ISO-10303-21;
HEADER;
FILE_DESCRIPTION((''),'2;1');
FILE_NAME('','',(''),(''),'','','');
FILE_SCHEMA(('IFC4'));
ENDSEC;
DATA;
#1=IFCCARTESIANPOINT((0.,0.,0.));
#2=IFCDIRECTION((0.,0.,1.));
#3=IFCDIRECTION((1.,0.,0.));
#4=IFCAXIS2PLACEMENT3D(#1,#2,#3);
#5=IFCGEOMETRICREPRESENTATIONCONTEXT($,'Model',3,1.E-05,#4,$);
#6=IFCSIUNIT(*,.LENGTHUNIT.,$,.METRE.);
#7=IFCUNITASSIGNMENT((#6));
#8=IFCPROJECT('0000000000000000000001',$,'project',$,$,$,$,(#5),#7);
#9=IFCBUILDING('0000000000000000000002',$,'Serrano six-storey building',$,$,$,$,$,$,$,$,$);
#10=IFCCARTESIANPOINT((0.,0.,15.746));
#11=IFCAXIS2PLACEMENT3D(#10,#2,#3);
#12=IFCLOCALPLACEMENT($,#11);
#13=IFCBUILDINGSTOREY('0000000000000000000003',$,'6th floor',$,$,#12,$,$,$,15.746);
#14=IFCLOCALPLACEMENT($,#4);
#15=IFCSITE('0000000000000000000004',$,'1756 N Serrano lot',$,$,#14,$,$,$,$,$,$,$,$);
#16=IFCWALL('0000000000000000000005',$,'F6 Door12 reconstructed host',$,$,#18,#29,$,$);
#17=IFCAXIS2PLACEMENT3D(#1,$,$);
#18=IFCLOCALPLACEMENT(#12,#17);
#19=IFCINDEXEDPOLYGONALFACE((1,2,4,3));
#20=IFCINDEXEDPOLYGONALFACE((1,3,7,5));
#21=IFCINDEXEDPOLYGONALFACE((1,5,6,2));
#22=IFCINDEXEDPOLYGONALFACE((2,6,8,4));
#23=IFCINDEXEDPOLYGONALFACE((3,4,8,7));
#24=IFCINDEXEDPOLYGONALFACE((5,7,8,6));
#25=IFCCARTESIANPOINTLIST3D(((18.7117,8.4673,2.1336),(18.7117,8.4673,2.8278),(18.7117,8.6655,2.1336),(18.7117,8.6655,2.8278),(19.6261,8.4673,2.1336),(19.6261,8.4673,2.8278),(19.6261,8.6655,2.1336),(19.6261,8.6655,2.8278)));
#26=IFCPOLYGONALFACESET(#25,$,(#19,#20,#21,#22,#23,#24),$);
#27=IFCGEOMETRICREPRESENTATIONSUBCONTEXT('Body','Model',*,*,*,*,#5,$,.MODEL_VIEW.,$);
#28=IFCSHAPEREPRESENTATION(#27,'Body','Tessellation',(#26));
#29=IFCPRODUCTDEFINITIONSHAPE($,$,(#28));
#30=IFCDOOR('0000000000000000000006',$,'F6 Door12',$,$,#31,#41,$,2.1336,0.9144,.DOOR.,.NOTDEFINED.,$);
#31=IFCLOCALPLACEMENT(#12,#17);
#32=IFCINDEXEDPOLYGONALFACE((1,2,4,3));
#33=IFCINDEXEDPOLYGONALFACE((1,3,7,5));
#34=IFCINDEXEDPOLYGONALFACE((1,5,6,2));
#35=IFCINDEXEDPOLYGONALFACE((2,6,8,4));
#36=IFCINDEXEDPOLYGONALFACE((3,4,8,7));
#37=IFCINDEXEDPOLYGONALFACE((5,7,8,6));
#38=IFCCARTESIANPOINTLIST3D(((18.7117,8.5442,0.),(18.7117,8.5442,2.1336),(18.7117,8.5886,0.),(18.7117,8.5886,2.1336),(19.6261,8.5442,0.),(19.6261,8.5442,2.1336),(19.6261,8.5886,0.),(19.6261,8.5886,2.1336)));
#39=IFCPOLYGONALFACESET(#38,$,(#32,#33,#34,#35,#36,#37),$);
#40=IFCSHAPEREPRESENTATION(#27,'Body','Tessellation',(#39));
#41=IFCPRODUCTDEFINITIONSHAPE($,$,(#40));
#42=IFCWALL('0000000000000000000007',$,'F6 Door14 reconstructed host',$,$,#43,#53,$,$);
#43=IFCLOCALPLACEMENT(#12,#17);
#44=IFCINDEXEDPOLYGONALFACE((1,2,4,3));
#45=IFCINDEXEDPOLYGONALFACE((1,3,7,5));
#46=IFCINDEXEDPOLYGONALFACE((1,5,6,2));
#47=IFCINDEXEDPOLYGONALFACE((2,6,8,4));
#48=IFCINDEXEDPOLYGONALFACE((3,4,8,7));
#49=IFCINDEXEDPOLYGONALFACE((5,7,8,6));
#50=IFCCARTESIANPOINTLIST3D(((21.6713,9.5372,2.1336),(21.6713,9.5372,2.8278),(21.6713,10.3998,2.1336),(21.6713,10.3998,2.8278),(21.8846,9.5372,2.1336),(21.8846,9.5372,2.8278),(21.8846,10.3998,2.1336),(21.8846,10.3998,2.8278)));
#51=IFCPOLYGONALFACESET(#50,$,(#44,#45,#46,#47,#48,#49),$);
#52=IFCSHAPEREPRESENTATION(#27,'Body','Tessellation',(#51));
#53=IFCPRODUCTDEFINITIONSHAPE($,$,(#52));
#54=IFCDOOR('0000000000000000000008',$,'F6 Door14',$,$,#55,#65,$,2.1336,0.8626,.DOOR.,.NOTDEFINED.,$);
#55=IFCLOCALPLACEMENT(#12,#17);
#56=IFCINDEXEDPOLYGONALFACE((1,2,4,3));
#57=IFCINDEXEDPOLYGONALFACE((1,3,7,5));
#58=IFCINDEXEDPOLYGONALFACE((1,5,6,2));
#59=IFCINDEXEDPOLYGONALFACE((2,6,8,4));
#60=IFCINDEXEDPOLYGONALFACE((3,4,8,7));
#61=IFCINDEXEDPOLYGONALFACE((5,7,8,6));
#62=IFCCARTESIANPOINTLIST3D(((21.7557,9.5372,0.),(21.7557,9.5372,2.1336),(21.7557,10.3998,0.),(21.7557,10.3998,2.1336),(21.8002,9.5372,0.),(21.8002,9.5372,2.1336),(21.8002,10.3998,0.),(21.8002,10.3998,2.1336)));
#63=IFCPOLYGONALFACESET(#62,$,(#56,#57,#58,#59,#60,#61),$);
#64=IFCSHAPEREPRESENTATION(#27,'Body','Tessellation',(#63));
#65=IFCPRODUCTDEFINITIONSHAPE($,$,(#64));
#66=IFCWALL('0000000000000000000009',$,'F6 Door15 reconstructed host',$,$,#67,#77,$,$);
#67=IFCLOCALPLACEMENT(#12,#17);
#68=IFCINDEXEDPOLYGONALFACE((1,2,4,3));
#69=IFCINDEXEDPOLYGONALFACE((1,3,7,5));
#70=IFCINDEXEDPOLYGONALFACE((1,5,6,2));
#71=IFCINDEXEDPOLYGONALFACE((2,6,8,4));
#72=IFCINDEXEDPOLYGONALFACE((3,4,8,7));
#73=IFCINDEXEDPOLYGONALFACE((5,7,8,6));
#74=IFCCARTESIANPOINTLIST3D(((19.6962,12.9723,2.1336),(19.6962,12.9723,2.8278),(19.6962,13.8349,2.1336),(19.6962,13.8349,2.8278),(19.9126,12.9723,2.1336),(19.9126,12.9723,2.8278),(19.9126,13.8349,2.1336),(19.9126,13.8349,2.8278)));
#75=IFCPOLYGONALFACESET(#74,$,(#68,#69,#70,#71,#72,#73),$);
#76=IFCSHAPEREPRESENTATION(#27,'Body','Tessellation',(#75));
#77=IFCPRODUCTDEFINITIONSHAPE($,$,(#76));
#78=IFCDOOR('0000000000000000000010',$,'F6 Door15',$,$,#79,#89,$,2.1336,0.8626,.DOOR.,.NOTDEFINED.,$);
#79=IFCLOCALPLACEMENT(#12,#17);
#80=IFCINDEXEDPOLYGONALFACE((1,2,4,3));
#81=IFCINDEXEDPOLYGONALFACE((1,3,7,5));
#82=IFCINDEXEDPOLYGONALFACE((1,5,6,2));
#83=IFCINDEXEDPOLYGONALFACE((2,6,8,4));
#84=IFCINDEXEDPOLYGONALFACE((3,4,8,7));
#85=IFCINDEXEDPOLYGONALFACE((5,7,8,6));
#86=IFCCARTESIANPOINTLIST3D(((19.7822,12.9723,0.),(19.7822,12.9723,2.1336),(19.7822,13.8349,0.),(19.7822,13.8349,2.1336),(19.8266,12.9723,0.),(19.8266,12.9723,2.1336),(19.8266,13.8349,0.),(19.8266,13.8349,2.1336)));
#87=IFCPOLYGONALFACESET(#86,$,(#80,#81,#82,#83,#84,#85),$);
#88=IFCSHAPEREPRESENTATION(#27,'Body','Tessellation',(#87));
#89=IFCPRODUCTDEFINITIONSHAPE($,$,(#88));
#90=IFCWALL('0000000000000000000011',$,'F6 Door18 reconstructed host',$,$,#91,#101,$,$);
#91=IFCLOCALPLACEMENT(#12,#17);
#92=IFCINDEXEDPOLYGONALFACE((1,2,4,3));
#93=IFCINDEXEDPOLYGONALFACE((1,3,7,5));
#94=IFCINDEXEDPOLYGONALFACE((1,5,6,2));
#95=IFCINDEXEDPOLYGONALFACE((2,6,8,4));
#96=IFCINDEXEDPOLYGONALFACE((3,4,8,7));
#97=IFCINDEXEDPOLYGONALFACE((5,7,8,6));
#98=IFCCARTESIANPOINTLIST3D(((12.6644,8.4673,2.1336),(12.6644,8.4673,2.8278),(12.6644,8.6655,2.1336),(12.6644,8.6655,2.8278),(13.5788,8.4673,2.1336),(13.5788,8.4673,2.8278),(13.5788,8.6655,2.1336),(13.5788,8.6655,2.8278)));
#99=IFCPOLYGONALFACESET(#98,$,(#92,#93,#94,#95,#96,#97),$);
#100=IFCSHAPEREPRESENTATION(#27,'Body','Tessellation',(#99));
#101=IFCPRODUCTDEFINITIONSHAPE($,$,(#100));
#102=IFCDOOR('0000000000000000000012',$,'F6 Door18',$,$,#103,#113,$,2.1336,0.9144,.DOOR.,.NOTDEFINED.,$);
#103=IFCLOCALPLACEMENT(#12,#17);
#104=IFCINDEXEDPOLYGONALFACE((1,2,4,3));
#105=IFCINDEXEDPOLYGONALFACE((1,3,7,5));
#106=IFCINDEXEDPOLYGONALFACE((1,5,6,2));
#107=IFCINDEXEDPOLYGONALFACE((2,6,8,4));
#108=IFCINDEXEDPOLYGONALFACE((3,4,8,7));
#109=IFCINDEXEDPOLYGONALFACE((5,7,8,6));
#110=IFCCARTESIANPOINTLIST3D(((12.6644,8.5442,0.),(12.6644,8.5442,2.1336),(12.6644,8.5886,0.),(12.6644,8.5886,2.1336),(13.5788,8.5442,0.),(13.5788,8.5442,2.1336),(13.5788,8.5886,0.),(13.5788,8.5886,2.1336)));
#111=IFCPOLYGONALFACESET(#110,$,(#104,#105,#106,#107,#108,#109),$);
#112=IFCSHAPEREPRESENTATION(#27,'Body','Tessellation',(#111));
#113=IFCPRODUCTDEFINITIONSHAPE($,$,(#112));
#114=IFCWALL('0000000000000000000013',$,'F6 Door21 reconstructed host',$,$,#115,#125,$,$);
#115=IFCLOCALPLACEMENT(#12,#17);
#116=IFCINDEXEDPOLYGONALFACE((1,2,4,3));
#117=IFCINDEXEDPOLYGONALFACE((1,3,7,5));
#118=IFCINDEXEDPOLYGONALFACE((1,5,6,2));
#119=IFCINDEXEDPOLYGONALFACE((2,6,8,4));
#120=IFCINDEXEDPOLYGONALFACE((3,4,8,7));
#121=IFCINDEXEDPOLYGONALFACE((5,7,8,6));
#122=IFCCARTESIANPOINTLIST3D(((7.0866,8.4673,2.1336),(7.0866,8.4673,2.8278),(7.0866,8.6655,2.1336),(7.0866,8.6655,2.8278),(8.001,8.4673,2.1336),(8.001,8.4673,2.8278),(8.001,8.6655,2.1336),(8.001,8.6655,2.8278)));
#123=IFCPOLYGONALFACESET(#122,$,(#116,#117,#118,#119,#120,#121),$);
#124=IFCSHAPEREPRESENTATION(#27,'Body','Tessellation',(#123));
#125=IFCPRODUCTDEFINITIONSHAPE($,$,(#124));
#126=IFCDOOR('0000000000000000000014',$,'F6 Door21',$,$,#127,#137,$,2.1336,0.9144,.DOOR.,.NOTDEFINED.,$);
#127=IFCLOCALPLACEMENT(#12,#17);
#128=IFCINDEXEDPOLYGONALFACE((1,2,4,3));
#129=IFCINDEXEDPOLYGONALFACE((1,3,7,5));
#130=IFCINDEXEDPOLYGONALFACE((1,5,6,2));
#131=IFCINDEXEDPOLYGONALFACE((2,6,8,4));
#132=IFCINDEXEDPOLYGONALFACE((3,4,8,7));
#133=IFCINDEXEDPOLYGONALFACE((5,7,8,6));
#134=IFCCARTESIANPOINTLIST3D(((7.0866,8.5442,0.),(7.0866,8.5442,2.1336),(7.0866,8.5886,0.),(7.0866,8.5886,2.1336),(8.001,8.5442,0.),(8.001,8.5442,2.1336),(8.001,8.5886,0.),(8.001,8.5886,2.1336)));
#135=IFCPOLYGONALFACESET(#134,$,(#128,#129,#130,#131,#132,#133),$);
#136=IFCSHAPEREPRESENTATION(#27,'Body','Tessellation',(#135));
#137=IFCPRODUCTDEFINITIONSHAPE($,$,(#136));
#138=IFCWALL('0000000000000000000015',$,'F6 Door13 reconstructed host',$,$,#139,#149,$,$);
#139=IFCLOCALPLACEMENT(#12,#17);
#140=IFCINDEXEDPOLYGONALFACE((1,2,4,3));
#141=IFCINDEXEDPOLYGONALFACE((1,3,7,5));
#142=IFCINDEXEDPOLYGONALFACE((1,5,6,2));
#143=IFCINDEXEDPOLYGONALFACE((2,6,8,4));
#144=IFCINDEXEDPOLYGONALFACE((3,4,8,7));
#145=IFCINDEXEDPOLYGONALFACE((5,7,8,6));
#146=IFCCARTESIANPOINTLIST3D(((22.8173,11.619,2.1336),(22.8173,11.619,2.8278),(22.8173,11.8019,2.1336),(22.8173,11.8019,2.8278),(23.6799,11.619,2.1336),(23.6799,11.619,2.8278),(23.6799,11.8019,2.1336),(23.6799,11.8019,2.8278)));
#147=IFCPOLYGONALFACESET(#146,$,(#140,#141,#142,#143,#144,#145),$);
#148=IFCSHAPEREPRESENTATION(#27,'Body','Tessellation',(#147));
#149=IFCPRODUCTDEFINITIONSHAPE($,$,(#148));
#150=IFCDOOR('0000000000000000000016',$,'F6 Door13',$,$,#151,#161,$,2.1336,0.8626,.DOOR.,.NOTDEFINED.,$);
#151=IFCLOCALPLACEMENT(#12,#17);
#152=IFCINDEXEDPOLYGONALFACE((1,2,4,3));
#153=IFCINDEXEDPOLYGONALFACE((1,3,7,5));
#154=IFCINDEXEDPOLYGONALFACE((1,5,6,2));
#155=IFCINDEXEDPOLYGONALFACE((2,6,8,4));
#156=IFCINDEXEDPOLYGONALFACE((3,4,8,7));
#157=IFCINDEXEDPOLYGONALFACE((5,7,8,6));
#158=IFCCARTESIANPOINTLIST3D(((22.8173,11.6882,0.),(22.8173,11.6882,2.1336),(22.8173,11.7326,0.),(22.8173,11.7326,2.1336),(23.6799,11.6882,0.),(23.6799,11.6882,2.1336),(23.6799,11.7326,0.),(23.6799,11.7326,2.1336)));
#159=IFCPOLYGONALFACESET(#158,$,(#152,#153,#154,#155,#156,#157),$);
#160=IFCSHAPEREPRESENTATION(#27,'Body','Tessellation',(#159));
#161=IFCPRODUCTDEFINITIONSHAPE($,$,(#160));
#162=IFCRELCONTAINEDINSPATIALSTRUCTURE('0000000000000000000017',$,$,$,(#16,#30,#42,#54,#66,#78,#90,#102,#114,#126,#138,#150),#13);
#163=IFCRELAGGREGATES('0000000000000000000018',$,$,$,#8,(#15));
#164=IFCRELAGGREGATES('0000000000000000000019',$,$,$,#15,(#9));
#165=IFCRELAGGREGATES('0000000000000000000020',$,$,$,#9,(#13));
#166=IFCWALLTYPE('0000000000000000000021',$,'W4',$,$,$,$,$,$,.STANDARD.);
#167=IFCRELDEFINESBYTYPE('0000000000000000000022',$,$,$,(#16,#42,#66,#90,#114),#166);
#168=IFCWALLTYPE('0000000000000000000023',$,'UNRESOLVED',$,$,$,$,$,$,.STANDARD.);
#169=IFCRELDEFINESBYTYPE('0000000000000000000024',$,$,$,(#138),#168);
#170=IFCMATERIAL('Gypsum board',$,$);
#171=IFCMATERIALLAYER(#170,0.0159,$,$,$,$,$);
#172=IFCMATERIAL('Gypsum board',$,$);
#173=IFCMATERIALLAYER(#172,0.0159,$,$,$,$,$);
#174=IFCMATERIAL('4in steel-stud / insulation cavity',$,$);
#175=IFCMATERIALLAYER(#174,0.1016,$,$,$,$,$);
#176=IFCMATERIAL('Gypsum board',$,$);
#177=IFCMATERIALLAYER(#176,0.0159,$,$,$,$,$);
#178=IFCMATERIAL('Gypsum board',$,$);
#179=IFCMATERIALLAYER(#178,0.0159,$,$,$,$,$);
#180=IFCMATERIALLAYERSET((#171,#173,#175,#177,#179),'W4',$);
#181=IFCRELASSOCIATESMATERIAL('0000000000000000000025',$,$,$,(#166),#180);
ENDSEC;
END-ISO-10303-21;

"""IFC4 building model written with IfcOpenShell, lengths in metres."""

from ifc_helpers import new_model, si_unit, frame, origin_with_axes, place, context, subcontext, project, spatial, polyline, outline, extrude, material, layer, layer_set, type_object, element, fill, save


model = new_model("IFC4")

# Units and contexts
model_context = context("Model", 3, precision=1e-05, world=origin_with_axes())
body_context = subcontext(model_context, "Body", "Model", "MODEL_VIEW")
ifc_project = project(units=[si_unit("LENGTHUNIT", "METRE")], contexts=[model_context])

# Site, building, storey
site_placement = place(None, origin_with_axes())
site = spatial("IfcSite", under=ifc_project, at=site_placement, Name="1756 N Serrano lot")
building = spatial("IfcBuilding", under=site, Name="Serrano six-storey building")
storey_placement = place(None, frame((0.0, 0.0, 15.746), z_axis=(0.0, 0.0, 1.0), x_axis=(1.0, 0.0, 0.0)))
storey = spatial("IfcBuildingStorey", under=building, at=storey_placement, Name="6th floor", Elevation=15.746)

# Walls, openings, doors
ifc_material_1 = material(Name="Gypsum board")
ifc_layer_1 = layer(ifc_material_1, 0.0159)
ifc_material_2 = material(Name="Gypsum board")
ifc_layer_2 = layer(ifc_material_2, 0.0159)
ifc_material_3 = material(Name="4in steel-stud / insulation cavity")
ifc_layer_3 = layer(ifc_material_3, 0.1016)
ifc_material_4 = material(Name="Gypsum board")
ifc_layer_4 = layer(ifc_material_4, 0.0159)
ifc_material_5 = material(Name="Gypsum board")
ifc_layer_5 = layer(ifc_material_5, 0.0159)
ifc_layer_set = layer_set([ifc_layer_1, ifc_layer_2, ifc_layer_3, ifc_layer_4, ifc_layer_5], Name="W4")
wall_type_1 = type_object("IfcWallType", Name="W4", PredefinedType="STANDARD", material=ifc_layer_set)
wall_1_placement = place(storey_placement, frame((0.0, 0.0, -15.746), z_axis=(0.0, 0.0, 1.0), x_axis=(1.0, 0.0, 0.0)))
wall_1 = element("IfcWall", 1, at=wall_1_placement, inside=storey, type_object=wall_type_1, Name="F6 Door12 reconstructed host", context=body_context, shape_type="SweptSolid", body=[
    extrude(outline(polyline([(18.7117, 8.4673), (18.7117, 8.6655), (19.6261, 8.6655), (19.6261, 8.4673), (18.7117, 8.4673)])), frame((0.0, 0.0, 15.746)), (0.0, 0.0, 1.0), 2.8278),
])
opening_1_placement = place(None, origin_with_axes())
opening_1 = element("IfcOpeningElement", 2, at=opening_1_placement, cuts=wall_1, PredefinedType="OPENING", context=body_context, shape_type="SweptSolid", body=[
    extrude(outline(polyline([(18.7117, 8.4491), (18.7117, 8.6838), (19.6261, 8.6838), (19.6261, 8.4491), (18.7117, 8.4491)])), frame((0.0, 0.0, 15.746)), (0.0, 0.0, 1.0), 2.1336),
])
door_1_placement = place(storey_placement, frame((0.0, 0.0, -15.746), z_axis=(0.0, 0.0, 1.0), x_axis=(1.0, 0.0, 0.0)))
door_1 = element("IfcDoor", 3, at=door_1_placement, inside=storey, Name="F6 Door12", OperationType="NOTDEFINED", OverallHeight=2.1336, OverallWidth=0.9144, PredefinedType="DOOR", context=body_context, shape_type="SweptSolid", body=[
    extrude(outline(polyline([(18.7117, 8.5442), (18.7117, 8.5886), (19.6261, 8.5886), (19.6261, 8.5442), (18.7117, 8.5442)])), frame((0.0, 0.0, 15.746)), (0.0, 0.0, 1.0), 2.1336),
])
fill(opening_1, door_1)
wall_2_placement = place(storey_placement, frame((0.0, 0.0, -15.746), z_axis=(0.0, 0.0, 1.0), x_axis=(1.0, 0.0, 0.0)))
wall_2 = element("IfcWall", 4, at=wall_2_placement, inside=storey, type_object=wall_type_1, Name="F6 Door14 reconstructed host", context=body_context, shape_type="SweptSolid", body=[
    extrude(outline(polyline([(21.6713, 10.3998), (21.8846, 10.3998), (21.8846, 9.5372), (21.6713, 9.5372), (21.6713, 10.3998)])), frame((0.0, 0.0, 15.746)), (0.0, 0.0, 1.0), 2.8278),
])
opening_2_placement = place(None, origin_with_axes())
opening_2 = element("IfcOpeningElement", 5, at=opening_2_placement, cuts=wall_2, PredefinedType="OPENING", context=body_context, shape_type="SweptSolid", body=[
    extrude(outline(polyline([(21.653, 10.3998), (21.9029, 10.3998), (21.9029, 9.5372), (21.653, 9.5372), (21.653, 10.3998)])), frame((0.0, 0.0, 15.746)), (0.0, 0.0, 1.0), 2.1336),
])
door_2_placement = place(storey_placement, frame((0.0, 0.0, -15.746), z_axis=(0.0, 0.0, 1.0), x_axis=(1.0, 0.0, 0.0)))
door_2 = element("IfcDoor", 6, at=door_2_placement, inside=storey, Name="F6 Door14", OperationType="NOTDEFINED", OverallHeight=2.1336, OverallWidth=0.8626, PredefinedType="DOOR", context=body_context, shape_type="SweptSolid", body=[
    extrude(outline(polyline([(21.7557, 10.3998), (21.8002, 10.3998), (21.8002, 9.5372), (21.7557, 9.5372), (21.7557, 10.3998)])), frame((0.0, 0.0, 15.746)), (0.0, 0.0, 1.0), 2.1336),
])
fill(opening_2, door_2)
wall_3_placement = place(storey_placement, frame((0.0, 0.0, -15.746), z_axis=(0.0, 0.0, 1.0), x_axis=(1.0, 0.0, 0.0)))
wall_3 = element("IfcWall", 7, at=wall_3_placement, inside=storey, type_object=wall_type_1, Name="F6 Door15 reconstructed host", context=body_context, shape_type="SweptSolid", body=[
    extrude(outline(polyline([(19.9126, 12.9723), (19.6962, 12.9723), (19.6962, 13.8349), (19.9126, 13.8349), (19.9126, 12.9723)])), frame((0.0, 0.0, 15.746)), (0.0, 0.0, 1.0), 2.8278),
])
opening_3_placement = place(None, origin_with_axes())
opening_3 = element("IfcOpeningElement", 8, at=opening_3_placement, cuts=wall_3, PredefinedType="OPENING", context=body_context, shape_type="SweptSolid", body=[
    extrude(outline(polyline([(19.9309, 12.9723), (19.6779, 12.9723), (19.6779, 13.8349), (19.9309, 13.8349), (19.9309, 12.9723)])), frame((0.0, 0.0, 15.746)), (0.0, 0.0, 1.0), 2.1336),
])
door_3_placement = place(storey_placement, frame((0.0, 0.0, -15.746), z_axis=(0.0, 0.0, 1.0), x_axis=(1.0, 0.0, 0.0)))
door_3 = element("IfcDoor", 9, at=door_3_placement, inside=storey, Name="F6 Door15", OperationType="NOTDEFINED", OverallHeight=2.1336, OverallWidth=0.8626, PredefinedType="DOOR", context=body_context, shape_type="SweptSolid", body=[
    extrude(outline(polyline([(19.8266, 12.9723), (19.7822, 12.9723), (19.7822, 13.8349), (19.8266, 13.8349), (19.8266, 12.9723)])), frame((0.0, 0.0, 15.746)), (0.0, 0.0, 1.0), 2.1336),
])
fill(opening_3, door_3)
wall_4_placement = place(storey_placement, frame((0.0, 0.0, -15.746), z_axis=(0.0, 0.0, 1.0), x_axis=(1.0, 0.0, 0.0)))
wall_4 = element("IfcWall", 10, at=wall_4_placement, inside=storey, type_object=wall_type_1, Name="F6 Door18 reconstructed host", context=body_context, shape_type="SweptSolid", body=[
    extrude(outline(polyline([(13.5788, 8.6655), (13.5788, 8.4673), (12.6644, 8.4673), (12.6644, 8.6655), (13.5788, 8.6655)])), frame((0.0, 0.0, 15.746)), (0.0, 0.0, 1.0), 2.8278),
])
opening_4_placement = place(None, origin_with_axes())
opening_4 = element("IfcOpeningElement", 11, at=opening_4_placement, cuts=wall_4, PredefinedType="OPENING", context=body_context, shape_type="SweptSolid", body=[
    extrude(outline(polyline([(13.5788, 8.6838), (13.5788, 8.4491), (12.6644, 8.4491), (12.6644, 8.6838), (13.5788, 8.6838)])), frame((0.0, 0.0, 15.746)), (0.0, 0.0, 1.0), 2.1336),
])
door_4_placement = place(storey_placement, frame((0.0, 0.0, -15.746), z_axis=(0.0, 0.0, 1.0), x_axis=(1.0, 0.0, 0.0)))
door_4 = element("IfcDoor", 12, at=door_4_placement, inside=storey, Name="F6 Door18", OperationType="NOTDEFINED", OverallHeight=2.1336, OverallWidth=0.9144, PredefinedType="DOOR", context=body_context, shape_type="SweptSolid", body=[
    extrude(outline(polyline([(13.5788, 8.5886), (13.5788, 8.5442), (12.6644, 8.5442), (12.6644, 8.5886), (13.5788, 8.5886)])), frame((0.0, 0.0, 15.746)), (0.0, 0.0, 1.0), 2.1336),
])
fill(opening_4, door_4)
wall_5_placement = place(storey_placement, frame((0.0, 0.0, -15.746), z_axis=(0.0, 0.0, 1.0), x_axis=(1.0, 0.0, 0.0)))
wall_5 = element("IfcWall", 13, at=wall_5_placement, inside=storey, type_object=wall_type_1, Name="F6 Door21 reconstructed host", context=body_context, shape_type="SweptSolid", body=[
    extrude(outline(polyline([(8.001, 8.6655), (8.001, 8.4673), (7.0866, 8.4673), (7.0866, 8.6655), (8.001, 8.6655)])), frame((0.0, 0.0, 15.746)), (0.0, 0.0, 1.0), 2.8278),
])
opening_5_placement = place(None, origin_with_axes())
opening_5 = element("IfcOpeningElement", 14, at=opening_5_placement, cuts=wall_5, PredefinedType="OPENING", context=body_context, shape_type="SweptSolid", body=[
    extrude(outline(polyline([(8.001, 8.6838), (8.001, 8.4491), (7.0866, 8.4491), (7.0866, 8.6838), (8.001, 8.6838)])), frame((0.0, 0.0, 15.746)), (0.0, 0.0, 1.0), 2.1336),
])
door_5_placement = place(storey_placement, frame((0.0, 0.0, -15.746), z_axis=(0.0, 0.0, 1.0), x_axis=(1.0, 0.0, 0.0)))
door_5 = element("IfcDoor", 15, at=door_5_placement, inside=storey, Name="F6 Door21", OperationType="NOTDEFINED", OverallHeight=2.1336, OverallWidth=0.9144, PredefinedType="DOOR", context=body_context, shape_type="SweptSolid", body=[
    extrude(outline(polyline([(8.001, 8.5886), (8.001, 8.5442), (7.0866, 8.5442), (7.0866, 8.5886), (8.001, 8.5886)])), frame((0.0, 0.0, 15.746)), (0.0, 0.0, 1.0), 2.1336),
])
fill(opening_5, door_5)
wall_type_2 = type_object("IfcWallType", Name="UNRESOLVED", PredefinedType="STANDARD")
wall_6_placement = place(storey_placement, frame((0.0, 0.0, -15.746), z_axis=(0.0, 0.0, 1.0), x_axis=(1.0, 0.0, 0.0)))
wall_6 = element("IfcWall", 16, at=wall_6_placement, inside=storey, type_object=wall_type_2, Name="F6 Door13 reconstructed host", context=body_context, shape_type="SweptSolid", body=[
    extrude(outline(polyline([(23.6799, 11.8019), (23.6799, 11.619), (22.8173, 11.619), (22.8173, 11.8019), (23.6799, 11.8019)])), frame((0.0, 0.0, 15.746)), (0.0, 0.0, 1.0), 2.8278),
])
opening_6_placement = place(None, origin_with_axes())
opening_6 = element("IfcOpeningElement", 17, at=opening_6_placement, cuts=wall_6, PredefinedType="OPENING", context=body_context, shape_type="SweptSolid", body=[
    extrude(outline(polyline([(23.6799, 11.8201), (23.6799, 11.6007), (22.8173, 11.6007), (22.8173, 11.8201), (23.6799, 11.8201)])), frame((0.0, 0.0, 15.746)), (0.0, 0.0, 1.0), 2.1336),
])
door_6_placement = place(storey_placement, frame((0.0, 0.0, -15.746), z_axis=(0.0, 0.0, 1.0), x_axis=(1.0, 0.0, 0.0)))
door_6 = element("IfcDoor", 18, at=door_6_placement, inside=storey, Name="F6 Door13", OperationType="NOTDEFINED", OverallHeight=2.1336, OverallWidth=0.8626, PredefinedType="DOOR", context=body_context, shape_type="SweptSolid", body=[
    extrude(outline(polyline([(23.6799, 11.7326), (23.6799, 11.6882), (22.8173, 11.6882), (22.8173, 11.7326), (23.6799, 11.7326)])), frame((0.0, 0.0, 15.746)), (0.0, 0.0, 1.0), 2.1336),
])
fill(opening_6, door_6)

save(model, "model.ifc")
